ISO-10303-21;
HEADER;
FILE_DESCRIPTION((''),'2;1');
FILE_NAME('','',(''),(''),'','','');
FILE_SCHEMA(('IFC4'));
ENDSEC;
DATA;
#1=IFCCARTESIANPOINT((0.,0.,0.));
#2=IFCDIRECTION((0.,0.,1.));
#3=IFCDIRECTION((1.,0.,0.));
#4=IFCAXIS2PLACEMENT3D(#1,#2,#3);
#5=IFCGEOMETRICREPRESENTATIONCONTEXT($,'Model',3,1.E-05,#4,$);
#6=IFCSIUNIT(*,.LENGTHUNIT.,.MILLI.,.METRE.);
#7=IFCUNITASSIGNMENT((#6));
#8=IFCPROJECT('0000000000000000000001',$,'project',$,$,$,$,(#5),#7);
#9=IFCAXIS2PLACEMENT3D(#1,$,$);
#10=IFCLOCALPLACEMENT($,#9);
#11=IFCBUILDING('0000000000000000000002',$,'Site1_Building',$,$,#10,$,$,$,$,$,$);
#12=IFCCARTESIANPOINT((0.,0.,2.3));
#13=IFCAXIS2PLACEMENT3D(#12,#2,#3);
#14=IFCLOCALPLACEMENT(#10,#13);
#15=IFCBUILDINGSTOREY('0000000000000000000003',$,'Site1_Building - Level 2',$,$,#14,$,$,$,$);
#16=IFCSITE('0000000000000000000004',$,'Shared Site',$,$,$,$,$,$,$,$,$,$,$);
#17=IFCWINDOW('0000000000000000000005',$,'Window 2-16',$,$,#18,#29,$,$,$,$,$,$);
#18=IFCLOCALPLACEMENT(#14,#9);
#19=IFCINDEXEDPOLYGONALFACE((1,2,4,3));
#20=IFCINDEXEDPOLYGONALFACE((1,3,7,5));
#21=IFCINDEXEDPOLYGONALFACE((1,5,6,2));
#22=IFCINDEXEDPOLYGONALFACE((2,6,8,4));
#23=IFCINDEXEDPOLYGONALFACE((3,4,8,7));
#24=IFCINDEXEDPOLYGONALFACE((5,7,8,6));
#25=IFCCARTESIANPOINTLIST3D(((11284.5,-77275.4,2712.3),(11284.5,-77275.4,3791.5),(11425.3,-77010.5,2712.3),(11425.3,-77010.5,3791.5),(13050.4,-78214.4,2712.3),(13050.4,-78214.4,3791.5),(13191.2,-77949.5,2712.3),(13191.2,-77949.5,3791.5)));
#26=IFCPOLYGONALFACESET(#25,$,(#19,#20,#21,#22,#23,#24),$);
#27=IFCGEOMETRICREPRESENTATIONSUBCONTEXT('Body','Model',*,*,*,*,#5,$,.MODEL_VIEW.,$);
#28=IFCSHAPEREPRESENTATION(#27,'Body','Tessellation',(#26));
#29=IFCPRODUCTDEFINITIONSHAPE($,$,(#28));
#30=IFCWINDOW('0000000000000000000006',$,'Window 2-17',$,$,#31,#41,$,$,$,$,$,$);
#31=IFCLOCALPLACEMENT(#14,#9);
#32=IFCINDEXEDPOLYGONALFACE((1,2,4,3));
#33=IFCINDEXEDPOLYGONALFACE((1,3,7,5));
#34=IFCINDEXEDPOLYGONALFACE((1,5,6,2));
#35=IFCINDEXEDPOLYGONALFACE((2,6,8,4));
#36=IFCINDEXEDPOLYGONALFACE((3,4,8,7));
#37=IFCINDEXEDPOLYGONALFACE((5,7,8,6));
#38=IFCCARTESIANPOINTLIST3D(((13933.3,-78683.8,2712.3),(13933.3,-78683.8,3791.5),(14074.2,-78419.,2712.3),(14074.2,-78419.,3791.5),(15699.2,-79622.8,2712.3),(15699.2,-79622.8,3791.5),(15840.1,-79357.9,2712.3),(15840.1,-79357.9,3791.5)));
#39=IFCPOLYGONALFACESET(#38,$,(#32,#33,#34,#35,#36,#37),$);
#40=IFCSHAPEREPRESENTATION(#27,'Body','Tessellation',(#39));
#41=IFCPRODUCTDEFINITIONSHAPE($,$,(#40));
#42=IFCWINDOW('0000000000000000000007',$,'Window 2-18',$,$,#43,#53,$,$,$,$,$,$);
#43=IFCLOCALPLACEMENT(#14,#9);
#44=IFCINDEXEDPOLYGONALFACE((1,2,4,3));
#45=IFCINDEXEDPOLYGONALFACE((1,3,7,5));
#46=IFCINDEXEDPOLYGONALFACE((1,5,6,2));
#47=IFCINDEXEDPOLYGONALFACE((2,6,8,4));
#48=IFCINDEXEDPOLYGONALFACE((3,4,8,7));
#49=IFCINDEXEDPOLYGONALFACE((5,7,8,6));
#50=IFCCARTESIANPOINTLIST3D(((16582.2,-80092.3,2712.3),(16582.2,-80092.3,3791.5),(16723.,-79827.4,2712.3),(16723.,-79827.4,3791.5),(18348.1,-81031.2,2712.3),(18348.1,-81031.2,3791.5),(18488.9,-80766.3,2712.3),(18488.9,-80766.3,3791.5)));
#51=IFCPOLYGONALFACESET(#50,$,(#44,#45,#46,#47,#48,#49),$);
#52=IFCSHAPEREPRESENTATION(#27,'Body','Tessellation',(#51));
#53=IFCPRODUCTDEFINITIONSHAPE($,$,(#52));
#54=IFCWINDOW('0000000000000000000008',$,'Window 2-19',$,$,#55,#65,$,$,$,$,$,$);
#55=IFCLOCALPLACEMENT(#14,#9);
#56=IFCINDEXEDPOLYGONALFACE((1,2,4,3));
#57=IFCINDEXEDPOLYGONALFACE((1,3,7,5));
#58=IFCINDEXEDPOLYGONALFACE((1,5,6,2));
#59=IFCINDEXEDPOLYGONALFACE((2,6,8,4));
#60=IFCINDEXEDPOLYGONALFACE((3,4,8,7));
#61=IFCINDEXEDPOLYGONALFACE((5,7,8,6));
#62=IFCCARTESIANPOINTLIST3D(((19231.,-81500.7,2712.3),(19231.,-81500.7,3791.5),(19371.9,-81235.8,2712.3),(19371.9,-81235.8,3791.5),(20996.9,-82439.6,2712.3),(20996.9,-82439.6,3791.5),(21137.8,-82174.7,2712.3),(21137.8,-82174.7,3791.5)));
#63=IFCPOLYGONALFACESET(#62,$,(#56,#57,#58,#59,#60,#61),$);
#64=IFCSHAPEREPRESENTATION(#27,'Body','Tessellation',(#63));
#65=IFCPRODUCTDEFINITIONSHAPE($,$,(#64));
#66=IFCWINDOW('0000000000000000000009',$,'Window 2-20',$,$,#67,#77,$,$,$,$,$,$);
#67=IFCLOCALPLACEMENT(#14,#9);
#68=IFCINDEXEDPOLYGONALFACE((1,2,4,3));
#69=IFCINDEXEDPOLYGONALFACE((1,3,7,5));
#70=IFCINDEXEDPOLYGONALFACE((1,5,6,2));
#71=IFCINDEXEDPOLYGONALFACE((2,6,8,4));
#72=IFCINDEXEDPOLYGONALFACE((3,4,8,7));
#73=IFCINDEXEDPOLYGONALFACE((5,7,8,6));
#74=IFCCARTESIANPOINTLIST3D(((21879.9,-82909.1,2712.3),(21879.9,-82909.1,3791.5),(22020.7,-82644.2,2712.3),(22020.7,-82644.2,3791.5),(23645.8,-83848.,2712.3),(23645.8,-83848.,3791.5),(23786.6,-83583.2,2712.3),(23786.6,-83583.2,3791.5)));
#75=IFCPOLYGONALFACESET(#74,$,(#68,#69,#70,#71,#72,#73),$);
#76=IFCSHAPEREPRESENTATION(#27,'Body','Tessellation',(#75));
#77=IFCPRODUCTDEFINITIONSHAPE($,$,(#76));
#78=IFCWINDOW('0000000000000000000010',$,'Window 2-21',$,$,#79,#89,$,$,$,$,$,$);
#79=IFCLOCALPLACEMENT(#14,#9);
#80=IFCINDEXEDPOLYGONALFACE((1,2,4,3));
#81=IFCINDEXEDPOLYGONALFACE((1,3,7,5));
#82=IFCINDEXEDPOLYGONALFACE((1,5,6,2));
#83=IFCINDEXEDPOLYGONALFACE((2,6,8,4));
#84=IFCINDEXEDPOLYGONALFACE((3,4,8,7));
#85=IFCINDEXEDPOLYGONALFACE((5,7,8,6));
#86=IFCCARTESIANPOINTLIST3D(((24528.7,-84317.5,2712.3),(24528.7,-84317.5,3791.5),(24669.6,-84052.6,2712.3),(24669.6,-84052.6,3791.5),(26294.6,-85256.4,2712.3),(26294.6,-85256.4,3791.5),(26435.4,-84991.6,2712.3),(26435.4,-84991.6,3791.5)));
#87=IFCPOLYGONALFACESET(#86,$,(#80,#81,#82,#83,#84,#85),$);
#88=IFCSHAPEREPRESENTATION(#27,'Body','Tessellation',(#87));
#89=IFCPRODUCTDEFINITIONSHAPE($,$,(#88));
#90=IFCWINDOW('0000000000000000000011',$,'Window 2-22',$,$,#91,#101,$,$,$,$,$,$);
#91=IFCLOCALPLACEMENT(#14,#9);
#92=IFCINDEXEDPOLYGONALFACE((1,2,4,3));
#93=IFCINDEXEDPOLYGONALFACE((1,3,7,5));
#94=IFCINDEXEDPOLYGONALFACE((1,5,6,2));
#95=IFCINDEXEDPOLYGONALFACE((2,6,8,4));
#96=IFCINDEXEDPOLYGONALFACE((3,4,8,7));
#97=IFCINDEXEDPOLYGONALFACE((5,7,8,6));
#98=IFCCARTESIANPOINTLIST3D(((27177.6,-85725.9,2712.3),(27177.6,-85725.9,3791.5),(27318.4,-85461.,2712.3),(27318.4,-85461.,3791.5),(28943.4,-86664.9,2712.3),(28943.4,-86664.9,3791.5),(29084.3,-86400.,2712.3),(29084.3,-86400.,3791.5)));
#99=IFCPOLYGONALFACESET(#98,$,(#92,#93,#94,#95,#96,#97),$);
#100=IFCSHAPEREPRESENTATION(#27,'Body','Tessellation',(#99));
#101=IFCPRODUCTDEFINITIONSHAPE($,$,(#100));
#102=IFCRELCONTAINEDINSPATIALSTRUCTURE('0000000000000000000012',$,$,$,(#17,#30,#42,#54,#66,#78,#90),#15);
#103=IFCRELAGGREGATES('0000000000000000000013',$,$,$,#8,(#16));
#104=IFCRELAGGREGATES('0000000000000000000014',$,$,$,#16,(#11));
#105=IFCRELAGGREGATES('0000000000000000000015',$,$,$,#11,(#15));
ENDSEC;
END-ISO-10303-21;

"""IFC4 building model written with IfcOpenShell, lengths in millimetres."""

from ifc_helpers import new_model, si_unit, frame, origin, origin_with_axes, place, context, subcontext, project, spatial, indexed_curve, outline, extrude, element, save


model = new_model("IFC4")

# Units and contexts
model_context = context("Model", 3, precision=1e-05, world=origin_with_axes())
body_context = subcontext(model_context, "Body", "Model", "MODEL_VIEW")
ifc_project = project(units=[si_unit("LENGTHUNIT", "METRE", prefix="MILLI")], contexts=[model_context])

# Site, building, storey
site = spatial("IfcSite", under=ifc_project, Name="Shared Site")
building_placement = place(None, origin())
building = spatial("IfcBuilding", under=site, at=building_placement, Name="Site1_Building")
storey_placement = place(building_placement, frame((0.0, 0.0, 2.3), z_axis=(0.0, 0.0, 1.0), x_axis=(1.0, 0.0, 0.0)))
storey = spatial("IfcBuildingStorey", under=building, at=storey_placement, Name="Site1_Building - Level 2")

# Windows
for number, where, z_axis, x_axis, name in (
    (1, (11284.5, -77275.4, 2712.3), (0.0, 0.0, 1.0), (0.882948, -0.469472, 0.0), "Window 2-16"),
    (2, (13933.3, -78683.8, 2712.3), (0.0, 0.0, 1.0), (0.882948, -0.469472, 0.0), "Window 2-17"),
    (3, (16582.2, -80092.3, 2712.3), (0.0, 0.0, 1.0), (0.882948, -0.469472, 0.0), "Window 2-18"),
    (4, (19231.0, -81500.7, 2712.3), (0.0, 0.0, 1.0), (0.882948, -0.469472, 0.0), "Window 2-19"),
    (5, (21879.9, -82909.1, 2712.3), (0.0, 0.0, 1.0), (0.882948, -0.469472, 0.0), "Window 2-20"),
    (6, (24528.7, -84317.5, 2712.3), (0.0, 0.0, 1.0), (0.882948, -0.469472, 0.0), "Window 2-21"),
    (7, (27177.6, -85725.9, 2712.3), (0.0, 0.0, 1.0), (0.882948, -0.469472, 0.0), "Window 2-22"),
):
    element("IfcWindow", number, at=place(storey_placement, frame(where, z_axis=z_axis, x_axis=x_axis)), inside=storey, Name=name, context=body_context, shape_type="SweptSolid", body=[
        extrude(outline(indexed_curve([(0.0, 0.0), (0.0, 300.0), (2000.0, 300.0), (2000.0, 0.0), (0.0, 0.0)], self_intersect=False)), origin_with_axes(), (0.0, 0.0, 1.0), 1079.3),
    ])

save(model, "model.ifc")
